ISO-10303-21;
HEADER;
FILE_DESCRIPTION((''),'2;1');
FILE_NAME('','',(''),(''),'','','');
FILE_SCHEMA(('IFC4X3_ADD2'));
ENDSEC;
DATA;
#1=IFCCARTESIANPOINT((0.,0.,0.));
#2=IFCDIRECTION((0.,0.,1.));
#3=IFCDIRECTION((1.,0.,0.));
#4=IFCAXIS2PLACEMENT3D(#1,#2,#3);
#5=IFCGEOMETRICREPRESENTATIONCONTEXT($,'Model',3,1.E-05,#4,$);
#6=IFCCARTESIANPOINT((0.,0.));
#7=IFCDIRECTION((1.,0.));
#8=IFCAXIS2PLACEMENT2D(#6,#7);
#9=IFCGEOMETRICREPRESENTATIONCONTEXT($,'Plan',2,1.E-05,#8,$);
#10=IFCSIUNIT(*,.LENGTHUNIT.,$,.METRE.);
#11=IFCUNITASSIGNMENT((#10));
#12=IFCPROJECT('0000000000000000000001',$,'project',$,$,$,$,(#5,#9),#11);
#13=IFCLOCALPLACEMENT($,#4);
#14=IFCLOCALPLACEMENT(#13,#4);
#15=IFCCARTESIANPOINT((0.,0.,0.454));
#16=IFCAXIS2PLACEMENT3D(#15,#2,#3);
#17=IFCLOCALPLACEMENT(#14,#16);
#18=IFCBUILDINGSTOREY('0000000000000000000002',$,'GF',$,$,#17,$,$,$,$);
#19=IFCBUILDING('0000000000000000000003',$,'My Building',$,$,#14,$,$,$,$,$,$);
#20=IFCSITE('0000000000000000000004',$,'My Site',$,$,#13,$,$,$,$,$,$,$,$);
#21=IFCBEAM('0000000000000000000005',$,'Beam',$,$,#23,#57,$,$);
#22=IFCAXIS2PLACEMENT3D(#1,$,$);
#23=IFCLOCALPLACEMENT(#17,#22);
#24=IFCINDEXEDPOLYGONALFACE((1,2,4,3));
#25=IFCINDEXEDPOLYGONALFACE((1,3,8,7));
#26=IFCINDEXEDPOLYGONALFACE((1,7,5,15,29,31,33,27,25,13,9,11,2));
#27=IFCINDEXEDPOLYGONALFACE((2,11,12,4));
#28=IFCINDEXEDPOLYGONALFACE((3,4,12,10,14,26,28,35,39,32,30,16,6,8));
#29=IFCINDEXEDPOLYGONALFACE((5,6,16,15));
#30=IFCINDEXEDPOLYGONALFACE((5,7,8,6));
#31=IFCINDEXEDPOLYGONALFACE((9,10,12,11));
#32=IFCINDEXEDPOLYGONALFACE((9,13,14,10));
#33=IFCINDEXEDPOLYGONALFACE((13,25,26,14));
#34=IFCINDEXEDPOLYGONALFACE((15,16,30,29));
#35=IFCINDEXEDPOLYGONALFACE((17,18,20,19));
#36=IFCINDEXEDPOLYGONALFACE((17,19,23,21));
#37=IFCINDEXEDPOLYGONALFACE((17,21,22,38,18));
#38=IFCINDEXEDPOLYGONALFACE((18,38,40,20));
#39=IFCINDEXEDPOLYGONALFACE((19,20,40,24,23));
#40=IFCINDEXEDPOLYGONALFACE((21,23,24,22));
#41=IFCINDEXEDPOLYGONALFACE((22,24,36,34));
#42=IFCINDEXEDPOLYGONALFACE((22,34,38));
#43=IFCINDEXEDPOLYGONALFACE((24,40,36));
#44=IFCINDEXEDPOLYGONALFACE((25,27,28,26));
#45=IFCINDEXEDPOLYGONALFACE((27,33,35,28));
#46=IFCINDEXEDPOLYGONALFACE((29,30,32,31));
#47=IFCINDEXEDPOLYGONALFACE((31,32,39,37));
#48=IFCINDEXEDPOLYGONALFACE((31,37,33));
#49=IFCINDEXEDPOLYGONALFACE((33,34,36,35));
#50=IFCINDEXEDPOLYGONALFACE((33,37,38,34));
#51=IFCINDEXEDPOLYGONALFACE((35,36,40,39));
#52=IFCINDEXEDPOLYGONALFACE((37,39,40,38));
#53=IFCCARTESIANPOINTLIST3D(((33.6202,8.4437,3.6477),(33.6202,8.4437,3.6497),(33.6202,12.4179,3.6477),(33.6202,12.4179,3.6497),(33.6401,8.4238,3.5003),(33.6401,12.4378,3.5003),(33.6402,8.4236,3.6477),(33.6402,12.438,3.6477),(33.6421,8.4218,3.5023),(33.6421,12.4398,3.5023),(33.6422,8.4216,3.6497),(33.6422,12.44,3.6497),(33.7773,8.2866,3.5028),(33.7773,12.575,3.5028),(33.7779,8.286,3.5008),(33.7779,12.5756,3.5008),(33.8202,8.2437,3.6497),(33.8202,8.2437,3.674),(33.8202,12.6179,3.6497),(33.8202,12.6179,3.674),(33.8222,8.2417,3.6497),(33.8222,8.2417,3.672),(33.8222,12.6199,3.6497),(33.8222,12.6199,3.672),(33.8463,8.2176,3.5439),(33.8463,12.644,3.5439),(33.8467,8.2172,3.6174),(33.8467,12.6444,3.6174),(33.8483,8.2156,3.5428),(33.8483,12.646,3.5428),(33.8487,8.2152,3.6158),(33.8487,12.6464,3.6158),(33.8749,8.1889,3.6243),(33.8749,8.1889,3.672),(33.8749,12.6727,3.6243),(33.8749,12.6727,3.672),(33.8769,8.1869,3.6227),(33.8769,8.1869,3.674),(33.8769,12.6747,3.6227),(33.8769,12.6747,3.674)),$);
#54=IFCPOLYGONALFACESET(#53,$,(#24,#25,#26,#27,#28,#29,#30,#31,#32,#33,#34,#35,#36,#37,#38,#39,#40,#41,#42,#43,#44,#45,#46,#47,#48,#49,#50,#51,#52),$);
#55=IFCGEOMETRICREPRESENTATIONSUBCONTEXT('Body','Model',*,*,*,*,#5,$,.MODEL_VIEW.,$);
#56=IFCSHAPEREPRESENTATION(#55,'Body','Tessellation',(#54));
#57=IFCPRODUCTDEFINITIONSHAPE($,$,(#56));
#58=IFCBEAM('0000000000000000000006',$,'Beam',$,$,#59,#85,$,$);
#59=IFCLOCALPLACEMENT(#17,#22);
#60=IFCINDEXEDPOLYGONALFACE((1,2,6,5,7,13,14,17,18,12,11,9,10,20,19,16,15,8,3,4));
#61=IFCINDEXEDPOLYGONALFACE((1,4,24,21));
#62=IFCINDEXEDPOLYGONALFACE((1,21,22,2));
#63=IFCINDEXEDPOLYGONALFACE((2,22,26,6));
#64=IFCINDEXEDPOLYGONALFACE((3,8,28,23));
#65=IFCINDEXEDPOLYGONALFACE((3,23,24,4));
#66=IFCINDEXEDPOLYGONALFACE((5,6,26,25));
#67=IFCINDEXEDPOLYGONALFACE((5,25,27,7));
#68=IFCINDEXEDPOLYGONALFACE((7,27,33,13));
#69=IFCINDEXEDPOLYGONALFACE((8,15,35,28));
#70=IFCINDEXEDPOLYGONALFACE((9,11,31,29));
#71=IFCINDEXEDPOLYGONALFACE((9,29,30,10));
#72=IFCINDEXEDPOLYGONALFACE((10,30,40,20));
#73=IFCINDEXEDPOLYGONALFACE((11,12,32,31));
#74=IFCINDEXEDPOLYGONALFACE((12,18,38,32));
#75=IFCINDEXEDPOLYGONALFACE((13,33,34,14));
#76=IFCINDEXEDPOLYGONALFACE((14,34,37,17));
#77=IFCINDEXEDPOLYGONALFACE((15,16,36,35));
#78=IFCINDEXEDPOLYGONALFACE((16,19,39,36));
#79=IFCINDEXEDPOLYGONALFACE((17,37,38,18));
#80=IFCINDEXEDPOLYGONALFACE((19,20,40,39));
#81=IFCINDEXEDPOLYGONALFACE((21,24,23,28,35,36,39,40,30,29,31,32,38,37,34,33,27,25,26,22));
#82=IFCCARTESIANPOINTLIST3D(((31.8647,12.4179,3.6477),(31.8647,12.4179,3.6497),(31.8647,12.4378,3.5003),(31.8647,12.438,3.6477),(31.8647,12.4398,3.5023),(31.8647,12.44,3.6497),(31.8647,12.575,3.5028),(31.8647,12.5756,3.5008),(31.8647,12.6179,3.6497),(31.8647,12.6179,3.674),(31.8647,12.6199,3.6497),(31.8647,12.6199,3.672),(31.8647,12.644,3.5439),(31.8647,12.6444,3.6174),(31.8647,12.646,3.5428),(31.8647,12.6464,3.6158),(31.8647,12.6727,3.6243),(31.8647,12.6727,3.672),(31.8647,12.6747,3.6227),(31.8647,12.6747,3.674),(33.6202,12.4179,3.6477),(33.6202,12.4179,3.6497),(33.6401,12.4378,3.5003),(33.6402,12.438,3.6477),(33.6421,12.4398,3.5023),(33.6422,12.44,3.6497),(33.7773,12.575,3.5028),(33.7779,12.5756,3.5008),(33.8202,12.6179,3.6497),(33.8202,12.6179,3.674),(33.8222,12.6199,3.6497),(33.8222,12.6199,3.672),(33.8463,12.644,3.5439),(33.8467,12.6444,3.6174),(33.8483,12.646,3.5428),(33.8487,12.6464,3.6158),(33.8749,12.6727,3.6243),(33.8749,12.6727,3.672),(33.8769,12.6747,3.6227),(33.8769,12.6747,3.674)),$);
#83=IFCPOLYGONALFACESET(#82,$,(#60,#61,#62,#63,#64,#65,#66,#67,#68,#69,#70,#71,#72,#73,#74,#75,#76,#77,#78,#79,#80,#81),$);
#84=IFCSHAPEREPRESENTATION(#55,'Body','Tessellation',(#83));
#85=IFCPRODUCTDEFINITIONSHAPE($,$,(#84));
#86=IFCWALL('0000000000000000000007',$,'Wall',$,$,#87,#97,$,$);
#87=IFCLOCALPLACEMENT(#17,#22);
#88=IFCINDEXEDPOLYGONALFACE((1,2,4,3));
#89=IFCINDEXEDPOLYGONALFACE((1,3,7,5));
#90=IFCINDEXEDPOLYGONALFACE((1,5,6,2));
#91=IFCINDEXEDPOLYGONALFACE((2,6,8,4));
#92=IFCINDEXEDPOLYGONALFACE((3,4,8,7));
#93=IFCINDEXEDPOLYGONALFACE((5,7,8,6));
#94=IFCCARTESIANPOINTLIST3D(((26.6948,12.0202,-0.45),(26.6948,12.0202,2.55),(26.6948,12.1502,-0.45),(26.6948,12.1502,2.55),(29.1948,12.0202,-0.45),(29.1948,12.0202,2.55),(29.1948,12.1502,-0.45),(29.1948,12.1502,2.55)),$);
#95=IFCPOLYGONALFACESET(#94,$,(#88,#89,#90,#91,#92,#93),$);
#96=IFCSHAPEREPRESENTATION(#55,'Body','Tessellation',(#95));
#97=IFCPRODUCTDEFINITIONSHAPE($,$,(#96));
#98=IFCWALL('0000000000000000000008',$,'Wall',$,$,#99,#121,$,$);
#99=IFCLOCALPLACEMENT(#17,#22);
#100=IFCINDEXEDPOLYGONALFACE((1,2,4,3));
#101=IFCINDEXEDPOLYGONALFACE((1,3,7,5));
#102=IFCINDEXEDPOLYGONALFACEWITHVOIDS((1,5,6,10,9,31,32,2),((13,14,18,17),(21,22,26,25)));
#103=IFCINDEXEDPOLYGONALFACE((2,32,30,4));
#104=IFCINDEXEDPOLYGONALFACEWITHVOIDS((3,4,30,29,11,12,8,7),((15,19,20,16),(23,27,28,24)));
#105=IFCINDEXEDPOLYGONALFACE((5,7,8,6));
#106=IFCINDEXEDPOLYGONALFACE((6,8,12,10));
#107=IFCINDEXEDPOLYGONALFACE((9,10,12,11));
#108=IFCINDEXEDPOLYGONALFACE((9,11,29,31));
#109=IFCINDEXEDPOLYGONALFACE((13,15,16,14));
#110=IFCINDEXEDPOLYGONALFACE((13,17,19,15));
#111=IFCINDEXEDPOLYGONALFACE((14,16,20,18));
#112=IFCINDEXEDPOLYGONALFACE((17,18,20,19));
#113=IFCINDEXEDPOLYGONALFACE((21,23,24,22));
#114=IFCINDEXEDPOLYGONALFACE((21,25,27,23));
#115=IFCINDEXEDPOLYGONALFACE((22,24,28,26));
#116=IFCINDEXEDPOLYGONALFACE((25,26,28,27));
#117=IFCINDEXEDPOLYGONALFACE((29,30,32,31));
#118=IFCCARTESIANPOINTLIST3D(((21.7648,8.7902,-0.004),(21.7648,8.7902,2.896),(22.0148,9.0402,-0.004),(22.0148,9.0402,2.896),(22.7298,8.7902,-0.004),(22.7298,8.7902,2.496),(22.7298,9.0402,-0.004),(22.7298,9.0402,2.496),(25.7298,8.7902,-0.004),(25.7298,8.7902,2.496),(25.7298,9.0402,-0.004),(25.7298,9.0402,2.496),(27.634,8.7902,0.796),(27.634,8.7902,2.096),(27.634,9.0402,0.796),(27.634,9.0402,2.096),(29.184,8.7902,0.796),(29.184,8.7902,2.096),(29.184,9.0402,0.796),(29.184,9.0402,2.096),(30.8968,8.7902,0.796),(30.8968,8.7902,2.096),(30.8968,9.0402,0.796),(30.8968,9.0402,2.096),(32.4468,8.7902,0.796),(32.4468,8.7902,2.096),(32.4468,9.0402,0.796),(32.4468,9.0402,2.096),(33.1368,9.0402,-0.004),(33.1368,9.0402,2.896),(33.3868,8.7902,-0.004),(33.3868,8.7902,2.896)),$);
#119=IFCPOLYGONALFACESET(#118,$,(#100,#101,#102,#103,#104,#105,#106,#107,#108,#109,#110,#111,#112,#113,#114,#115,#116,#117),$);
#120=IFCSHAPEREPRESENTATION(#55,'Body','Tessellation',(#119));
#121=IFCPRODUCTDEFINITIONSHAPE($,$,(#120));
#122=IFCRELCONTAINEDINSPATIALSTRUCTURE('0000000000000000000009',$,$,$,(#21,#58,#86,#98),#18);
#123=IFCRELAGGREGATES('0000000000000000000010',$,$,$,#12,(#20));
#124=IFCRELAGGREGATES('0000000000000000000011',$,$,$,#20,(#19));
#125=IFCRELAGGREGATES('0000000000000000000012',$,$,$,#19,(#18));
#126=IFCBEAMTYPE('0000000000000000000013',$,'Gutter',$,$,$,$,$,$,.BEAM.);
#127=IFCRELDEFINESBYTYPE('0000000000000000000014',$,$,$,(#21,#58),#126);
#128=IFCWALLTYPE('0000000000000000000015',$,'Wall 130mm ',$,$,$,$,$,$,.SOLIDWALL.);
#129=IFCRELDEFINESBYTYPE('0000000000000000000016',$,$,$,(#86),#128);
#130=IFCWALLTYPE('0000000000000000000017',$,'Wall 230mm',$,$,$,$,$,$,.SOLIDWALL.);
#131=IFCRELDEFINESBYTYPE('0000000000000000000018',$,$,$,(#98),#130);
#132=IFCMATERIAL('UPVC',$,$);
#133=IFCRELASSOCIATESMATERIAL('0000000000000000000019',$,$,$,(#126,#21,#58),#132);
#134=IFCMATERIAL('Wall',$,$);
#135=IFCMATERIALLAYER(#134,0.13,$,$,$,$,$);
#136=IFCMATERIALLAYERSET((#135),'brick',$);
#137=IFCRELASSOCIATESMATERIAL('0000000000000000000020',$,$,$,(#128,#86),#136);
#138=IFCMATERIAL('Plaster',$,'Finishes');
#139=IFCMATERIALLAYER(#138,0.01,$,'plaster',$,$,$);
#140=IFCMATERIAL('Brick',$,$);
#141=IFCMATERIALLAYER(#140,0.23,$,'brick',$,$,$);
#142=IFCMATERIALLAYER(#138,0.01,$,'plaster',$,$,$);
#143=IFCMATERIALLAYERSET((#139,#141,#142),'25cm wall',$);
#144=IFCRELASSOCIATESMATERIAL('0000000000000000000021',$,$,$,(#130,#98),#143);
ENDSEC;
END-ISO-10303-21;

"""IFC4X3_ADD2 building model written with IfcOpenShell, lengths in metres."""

from ifc_helpers import new_model, si_unit, frame, origin_with_axes, origin_2d_with_axis, place, context, subcontext, project, spatial, line, indexed_curve, outline, extrude, clip, halfspace, source, transform, mapped, material, layer, layer_set, layer_usage, material_profile, profile_set, profile_usage, type_object, element, save


model = new_model("IFC4X3_ADD2")

# Units and contexts
model_context = context("Model", 3, precision=1e-05, world=origin_with_axes())
plan_context = context("Plan", 2, precision=1e-05, world=origin_2d_with_axis())
body_context_1 = subcontext(model_context, "Body", "Model", "MODEL_VIEW")
ifc_project = project(units=[si_unit("LENGTHUNIT", "METRE")], contexts=[model_context, plan_context])

# Site, building, storey
site_placement = place(None, origin_with_axes())
site = spatial("IfcSite", under=ifc_project, at=site_placement, Name="My Site")
building_placement = place(site_placement, origin_with_axes())
building = spatial("IfcBuilding", under=site, at=building_placement, Name="My Building")
storey_placement = place(building_placement, frame((0.0, 0.0, 0.454), z_axis=(0.0, 0.0, 1.0), x_axis=(1.0, 0.0, 0.0)))
storey = spatial("IfcBuildingStorey", under=building, at=storey_placement, Name="GF")

# Beams
ifc_material_1 = material(Name="UPVC")
ifc_material_profile_1 = material_profile(ifc_material_1, outline(indexed_curve([(0.0548, 0.1717), (0.002, 0.1717), (0.002, 0.124), (0.0303, 0.1171), (0.0307, 0.0436), (0.0996, 0.0025), (0.2349, 0.002), (0.2347, 0.1494), (0.2567, 0.1494), (0.2567, 0.1474), (0.2367, 0.1474), (0.2369, 0.0), (0.0991, 0.0005), (0.0287, 0.0425), (0.0283, 0.1155), (0.0, 0.1224), (0.0, 0.1737), (0.0568, 0.1737), (0.0568, 0.1494), (0.0548, 0.1494), (0.0548, 0.1717)])))
ifc_profile_set_1 = profile_set([ifc_material_profile_1])
ifc_profile_usage_1 = profile_usage(ifc_profile_set_1)
beam_type = type_object("IfcBeamType", Name="Gutter", PredefinedType="BEAM", material=ifc_profile_set_1)
beam_1_placement = place(storey_placement, frame((33.8769, 8.1869, 3.5003), z_axis=(0.0, 1.0, 0.0), x_axis=(-1.0, 0.0, 0.0)))
element("IfcBeam", 1, at=beam_1_placement, inside=storey, type_object=beam_type, material=ifc_profile_usage_1, Name="Beam", context=body_context_1, shape_type="Clipping", body=[
    clip(clip(extrude(outline(indexed_curve([(0.0548, 0.1717), (0.002, 0.1717), (0.002, 0.124), (0.0303, 0.1171), (0.0307, 0.0436), (0.0996, 0.0025), (0.2349, 0.002), (0.2347, 0.1494), (0.2567, 0.1494), (0.2567, 0.1474), (0.2367, 0.1474), (0.2369, 0.0), (0.0991, 0.0005), (0.0287, 0.0425), (0.0283, 0.1155), (0.0, 0.1224), (0.0, 0.1737), (0.0568, 0.1737), (0.0568, 0.1494), (0.0548, 0.1494), (0.0548, 0.1717)])), origin_with_axes(), (0.0, 0.0, 1.0), 4.4877), halfspace(frame((0.0, -3.9543, 4.4877), z_axis=(0.707104, 0.0, 0.707109), x_axis=(0.0, -1.0, 0.0)), False)), halfspace(frame((0.0, -3.9543, 0.0), z_axis=(0.707104, 0.0, -0.70711), x_axis=(0.0, -1.0, 0.0)), False)),
])
ifc_profile_usage_2 = profile_usage(ifc_profile_set_1)
beam_2_placement = place(storey_placement, frame((33.8769, 12.6747, 3.5003), z_axis=(-1.0, 0.000001, 0.0), x_axis=(-0.000001, -1.0, 0.0)))
element("IfcBeam", 2, at=beam_2_placement, inside=storey, type_object=beam_type, material=ifc_profile_usage_2, Name="Beam", context=body_context_1, shape_type="Clipping", body=[
    clip(extrude(outline(indexed_curve([(0.0548, 0.1717), (0.002, 0.1717), (0.002, 0.124), (0.0303, 0.1171), (0.0307, 0.0436), (0.0996, 0.0025), (0.2349, 0.002), (0.2347, 0.1494), (0.2567, 0.1494), (0.2567, 0.1474), (0.2367, 0.1474), (0.2369, 0.0), (0.0991, 0.0005), (0.0287, 0.0425), (0.0283, 0.1155), (0.0, 0.1224), (0.0, 0.1737), (0.0568, 0.1737), (0.0568, 0.1494), (0.0548, 0.1494), (0.0548, 0.1717)])), origin_with_axes(), (0.0, 0.0, 1.0), 2.0122), halfspace(frame((0.0, -3.9543, 0.0), z_axis=(0.707109, 0.0, -0.707105), x_axis=(0.0, -1.0, 0.0)), False)),
])

# Wall
ifc_material_2 = material(Name="Wall")
ifc_layer_1 = layer(ifc_material_2, 0.13)
ifc_layer_set_1 = layer_set([ifc_layer_1], Name="brick")
ifc_layer_usage_1 = layer_usage(ifc_layer_set_1, "AXIS2", "POSITIVE", 0.0)
wall_type_1 = type_object("IfcWallType", Name="Wall 130mm ", PredefinedType="SOLIDWALL", material=ifc_layer_set_1)
wall_1_placement = place(storey_placement, frame((29.1948, 12.1502, -0.45), z_axis=(0.0, 0.0, 1.0), x_axis=(-1.0, 0.0, 0.0)))
element("IfcWall", 3, at=wall_1_placement, inside=storey, type_object=wall_type_1, material=ifc_layer_usage_1, Name="Wall", context=body_context_1, shape_type="SweptSolid", body=[
    extrude(outline(indexed_curve([(0.0, 0.0), (0.0, 0.13), (2.5, 0.13), (2.5, 0.0), (0.0, 0.0)], self_intersect=False)), origin_with_axes(), (0.0, 0.0, 1.0), 3.0),
])

# Wall, openings
ifc_material_3 = material(Name="Plaster", Category="Finishes")
ifc_layer_2 = layer(ifc_material_3, 0.01, Name="plaster")
ifc_material_4 = material(Name="Brick")
ifc_layer_3 = layer(ifc_material_4, 0.23, Name="brick")
ifc_layer_4 = layer(ifc_material_3, 0.01, Name="plaster")
ifc_layer_set_2 = layer_set([ifc_layer_2, ifc_layer_3, ifc_layer_4], Name="25cm wall")
ifc_layer_usage_2 = layer_usage(ifc_layer_set_2, "AXIS2", "NEGATIVE", 0.0)
wall_type_2 = type_object("IfcWallType", Name="Wall 230mm", PredefinedType="SOLIDWALL", material=ifc_layer_set_2)
wall_2_placement = place(storey_placement, frame((33.3868, 8.7902, -0.004), z_axis=(0.0, 0.0, 1.0), x_axis=(-1.0, 0.0, 0.0)))
wall_2 = element("IfcWall", 4, at=wall_2_placement, inside=storey, type_object=wall_type_2, material=ifc_layer_usage_2, Name="Wall", context=body_context_1, shape_type="SweptSolid", body=[
    extrude(outline(indexed_curve([(0.25, -0.25), (0.0, 0.0), (11.622, 0.0), (11.372, -0.25)], segments=[line(1, 2, 3, 4, 1)])), origin_with_axes(), (0.0, 0.0, 1.0), 2.9),
])
shared_shape_1 = source(origin_with_axes(), body_context_1, "Body", "SweptSolid", [
    extrude(outline(indexed_curve([(0.0, 0.0), (3.0, 0.0), (3.0, 2.5), (0.0, 2.5)], segments=[line(1, 2, 3, 4, 1)])), frame((0.0, -0.6, 0.0), z_axis=(0.0, -1.0, 0.0), x_axis=(1.0, 0.0, 0.0)), (0.0, 0.0, -1.0), 1.2),
])
opening_1_placement = place(wall_2_placement, frame((7.657, 0.0, 0.0), z_axis=(0.0, 0.0, 1.0), x_axis=(1.0, 0.0, 0.0)))
element("IfcOpeningElement", 5, at=opening_1_placement, cuts=wall_2, PredefinedType="OPENING", context=body_context_1, shape_type="MappedRepresentation", body=[
    mapped(shared_shape_1, transform((0.0, 0.0, 0.0), x_axis=(1.0, 0.0, 0.0), y_axis=(0.0, 1.0, 0.0), z_axis=(0.0, 0.0, 1.0), scale=1.0)),
])
shared_shape_2 = source(origin_with_axes(), body_context_1, "Body", "SweptSolid", [
    extrude(outline(indexed_curve([(0.0, 0.0), (1.55, 0.0), (1.55, 1.3), (0.0, 1.3)], segments=[line(1, 2, 3, 4, 1)])), frame((-0.775, -0.6, 0.0), z_axis=(0.0, -1.0, 0.0), x_axis=(1.0, 0.0, 0.0)), (0.0, 0.0, -1.0), 1.2),
])
opening_2_placement = place(wall_2_placement, frame((1.7149, 0.0, 0.8), z_axis=(0.0, 0.0, 1.0), x_axis=(1.0, 0.0, 0.0)))
element("IfcOpeningElement", 6, at=opening_2_placement, cuts=wall_2, PredefinedType="OPENING", context=body_context_1, shape_type="MappedRepresentation", body=[
    mapped(shared_shape_2, transform((0.0, 0.0, 0.0), x_axis=(1.0, 0.0, 0.0), y_axis=(0.0, 1.0, 0.0), z_axis=(0.0, 0.0, 1.0), scale=1.0)),
])
opening_3_placement = place(wall_2_placement, frame((4.9778, 0.0, 0.8), z_axis=(0.0, 0.0, 1.0), x_axis=(1.0, 0.0, 0.0)))
element("IfcOpeningElement", 7, at=opening_3_placement, cuts=wall_2, PredefinedType="OPENING", context=body_context_1, shape_type="MappedRepresentation", body=[
    mapped(shared_shape_2, transform((0.0, 0.0, 0.0), x_axis=(1.0, 0.0, 0.0), y_axis=(0.0, 1.0, 0.0), z_axis=(0.0, 0.0, 1.0), scale=1.0)),
])

save(model, "model.ifc")
